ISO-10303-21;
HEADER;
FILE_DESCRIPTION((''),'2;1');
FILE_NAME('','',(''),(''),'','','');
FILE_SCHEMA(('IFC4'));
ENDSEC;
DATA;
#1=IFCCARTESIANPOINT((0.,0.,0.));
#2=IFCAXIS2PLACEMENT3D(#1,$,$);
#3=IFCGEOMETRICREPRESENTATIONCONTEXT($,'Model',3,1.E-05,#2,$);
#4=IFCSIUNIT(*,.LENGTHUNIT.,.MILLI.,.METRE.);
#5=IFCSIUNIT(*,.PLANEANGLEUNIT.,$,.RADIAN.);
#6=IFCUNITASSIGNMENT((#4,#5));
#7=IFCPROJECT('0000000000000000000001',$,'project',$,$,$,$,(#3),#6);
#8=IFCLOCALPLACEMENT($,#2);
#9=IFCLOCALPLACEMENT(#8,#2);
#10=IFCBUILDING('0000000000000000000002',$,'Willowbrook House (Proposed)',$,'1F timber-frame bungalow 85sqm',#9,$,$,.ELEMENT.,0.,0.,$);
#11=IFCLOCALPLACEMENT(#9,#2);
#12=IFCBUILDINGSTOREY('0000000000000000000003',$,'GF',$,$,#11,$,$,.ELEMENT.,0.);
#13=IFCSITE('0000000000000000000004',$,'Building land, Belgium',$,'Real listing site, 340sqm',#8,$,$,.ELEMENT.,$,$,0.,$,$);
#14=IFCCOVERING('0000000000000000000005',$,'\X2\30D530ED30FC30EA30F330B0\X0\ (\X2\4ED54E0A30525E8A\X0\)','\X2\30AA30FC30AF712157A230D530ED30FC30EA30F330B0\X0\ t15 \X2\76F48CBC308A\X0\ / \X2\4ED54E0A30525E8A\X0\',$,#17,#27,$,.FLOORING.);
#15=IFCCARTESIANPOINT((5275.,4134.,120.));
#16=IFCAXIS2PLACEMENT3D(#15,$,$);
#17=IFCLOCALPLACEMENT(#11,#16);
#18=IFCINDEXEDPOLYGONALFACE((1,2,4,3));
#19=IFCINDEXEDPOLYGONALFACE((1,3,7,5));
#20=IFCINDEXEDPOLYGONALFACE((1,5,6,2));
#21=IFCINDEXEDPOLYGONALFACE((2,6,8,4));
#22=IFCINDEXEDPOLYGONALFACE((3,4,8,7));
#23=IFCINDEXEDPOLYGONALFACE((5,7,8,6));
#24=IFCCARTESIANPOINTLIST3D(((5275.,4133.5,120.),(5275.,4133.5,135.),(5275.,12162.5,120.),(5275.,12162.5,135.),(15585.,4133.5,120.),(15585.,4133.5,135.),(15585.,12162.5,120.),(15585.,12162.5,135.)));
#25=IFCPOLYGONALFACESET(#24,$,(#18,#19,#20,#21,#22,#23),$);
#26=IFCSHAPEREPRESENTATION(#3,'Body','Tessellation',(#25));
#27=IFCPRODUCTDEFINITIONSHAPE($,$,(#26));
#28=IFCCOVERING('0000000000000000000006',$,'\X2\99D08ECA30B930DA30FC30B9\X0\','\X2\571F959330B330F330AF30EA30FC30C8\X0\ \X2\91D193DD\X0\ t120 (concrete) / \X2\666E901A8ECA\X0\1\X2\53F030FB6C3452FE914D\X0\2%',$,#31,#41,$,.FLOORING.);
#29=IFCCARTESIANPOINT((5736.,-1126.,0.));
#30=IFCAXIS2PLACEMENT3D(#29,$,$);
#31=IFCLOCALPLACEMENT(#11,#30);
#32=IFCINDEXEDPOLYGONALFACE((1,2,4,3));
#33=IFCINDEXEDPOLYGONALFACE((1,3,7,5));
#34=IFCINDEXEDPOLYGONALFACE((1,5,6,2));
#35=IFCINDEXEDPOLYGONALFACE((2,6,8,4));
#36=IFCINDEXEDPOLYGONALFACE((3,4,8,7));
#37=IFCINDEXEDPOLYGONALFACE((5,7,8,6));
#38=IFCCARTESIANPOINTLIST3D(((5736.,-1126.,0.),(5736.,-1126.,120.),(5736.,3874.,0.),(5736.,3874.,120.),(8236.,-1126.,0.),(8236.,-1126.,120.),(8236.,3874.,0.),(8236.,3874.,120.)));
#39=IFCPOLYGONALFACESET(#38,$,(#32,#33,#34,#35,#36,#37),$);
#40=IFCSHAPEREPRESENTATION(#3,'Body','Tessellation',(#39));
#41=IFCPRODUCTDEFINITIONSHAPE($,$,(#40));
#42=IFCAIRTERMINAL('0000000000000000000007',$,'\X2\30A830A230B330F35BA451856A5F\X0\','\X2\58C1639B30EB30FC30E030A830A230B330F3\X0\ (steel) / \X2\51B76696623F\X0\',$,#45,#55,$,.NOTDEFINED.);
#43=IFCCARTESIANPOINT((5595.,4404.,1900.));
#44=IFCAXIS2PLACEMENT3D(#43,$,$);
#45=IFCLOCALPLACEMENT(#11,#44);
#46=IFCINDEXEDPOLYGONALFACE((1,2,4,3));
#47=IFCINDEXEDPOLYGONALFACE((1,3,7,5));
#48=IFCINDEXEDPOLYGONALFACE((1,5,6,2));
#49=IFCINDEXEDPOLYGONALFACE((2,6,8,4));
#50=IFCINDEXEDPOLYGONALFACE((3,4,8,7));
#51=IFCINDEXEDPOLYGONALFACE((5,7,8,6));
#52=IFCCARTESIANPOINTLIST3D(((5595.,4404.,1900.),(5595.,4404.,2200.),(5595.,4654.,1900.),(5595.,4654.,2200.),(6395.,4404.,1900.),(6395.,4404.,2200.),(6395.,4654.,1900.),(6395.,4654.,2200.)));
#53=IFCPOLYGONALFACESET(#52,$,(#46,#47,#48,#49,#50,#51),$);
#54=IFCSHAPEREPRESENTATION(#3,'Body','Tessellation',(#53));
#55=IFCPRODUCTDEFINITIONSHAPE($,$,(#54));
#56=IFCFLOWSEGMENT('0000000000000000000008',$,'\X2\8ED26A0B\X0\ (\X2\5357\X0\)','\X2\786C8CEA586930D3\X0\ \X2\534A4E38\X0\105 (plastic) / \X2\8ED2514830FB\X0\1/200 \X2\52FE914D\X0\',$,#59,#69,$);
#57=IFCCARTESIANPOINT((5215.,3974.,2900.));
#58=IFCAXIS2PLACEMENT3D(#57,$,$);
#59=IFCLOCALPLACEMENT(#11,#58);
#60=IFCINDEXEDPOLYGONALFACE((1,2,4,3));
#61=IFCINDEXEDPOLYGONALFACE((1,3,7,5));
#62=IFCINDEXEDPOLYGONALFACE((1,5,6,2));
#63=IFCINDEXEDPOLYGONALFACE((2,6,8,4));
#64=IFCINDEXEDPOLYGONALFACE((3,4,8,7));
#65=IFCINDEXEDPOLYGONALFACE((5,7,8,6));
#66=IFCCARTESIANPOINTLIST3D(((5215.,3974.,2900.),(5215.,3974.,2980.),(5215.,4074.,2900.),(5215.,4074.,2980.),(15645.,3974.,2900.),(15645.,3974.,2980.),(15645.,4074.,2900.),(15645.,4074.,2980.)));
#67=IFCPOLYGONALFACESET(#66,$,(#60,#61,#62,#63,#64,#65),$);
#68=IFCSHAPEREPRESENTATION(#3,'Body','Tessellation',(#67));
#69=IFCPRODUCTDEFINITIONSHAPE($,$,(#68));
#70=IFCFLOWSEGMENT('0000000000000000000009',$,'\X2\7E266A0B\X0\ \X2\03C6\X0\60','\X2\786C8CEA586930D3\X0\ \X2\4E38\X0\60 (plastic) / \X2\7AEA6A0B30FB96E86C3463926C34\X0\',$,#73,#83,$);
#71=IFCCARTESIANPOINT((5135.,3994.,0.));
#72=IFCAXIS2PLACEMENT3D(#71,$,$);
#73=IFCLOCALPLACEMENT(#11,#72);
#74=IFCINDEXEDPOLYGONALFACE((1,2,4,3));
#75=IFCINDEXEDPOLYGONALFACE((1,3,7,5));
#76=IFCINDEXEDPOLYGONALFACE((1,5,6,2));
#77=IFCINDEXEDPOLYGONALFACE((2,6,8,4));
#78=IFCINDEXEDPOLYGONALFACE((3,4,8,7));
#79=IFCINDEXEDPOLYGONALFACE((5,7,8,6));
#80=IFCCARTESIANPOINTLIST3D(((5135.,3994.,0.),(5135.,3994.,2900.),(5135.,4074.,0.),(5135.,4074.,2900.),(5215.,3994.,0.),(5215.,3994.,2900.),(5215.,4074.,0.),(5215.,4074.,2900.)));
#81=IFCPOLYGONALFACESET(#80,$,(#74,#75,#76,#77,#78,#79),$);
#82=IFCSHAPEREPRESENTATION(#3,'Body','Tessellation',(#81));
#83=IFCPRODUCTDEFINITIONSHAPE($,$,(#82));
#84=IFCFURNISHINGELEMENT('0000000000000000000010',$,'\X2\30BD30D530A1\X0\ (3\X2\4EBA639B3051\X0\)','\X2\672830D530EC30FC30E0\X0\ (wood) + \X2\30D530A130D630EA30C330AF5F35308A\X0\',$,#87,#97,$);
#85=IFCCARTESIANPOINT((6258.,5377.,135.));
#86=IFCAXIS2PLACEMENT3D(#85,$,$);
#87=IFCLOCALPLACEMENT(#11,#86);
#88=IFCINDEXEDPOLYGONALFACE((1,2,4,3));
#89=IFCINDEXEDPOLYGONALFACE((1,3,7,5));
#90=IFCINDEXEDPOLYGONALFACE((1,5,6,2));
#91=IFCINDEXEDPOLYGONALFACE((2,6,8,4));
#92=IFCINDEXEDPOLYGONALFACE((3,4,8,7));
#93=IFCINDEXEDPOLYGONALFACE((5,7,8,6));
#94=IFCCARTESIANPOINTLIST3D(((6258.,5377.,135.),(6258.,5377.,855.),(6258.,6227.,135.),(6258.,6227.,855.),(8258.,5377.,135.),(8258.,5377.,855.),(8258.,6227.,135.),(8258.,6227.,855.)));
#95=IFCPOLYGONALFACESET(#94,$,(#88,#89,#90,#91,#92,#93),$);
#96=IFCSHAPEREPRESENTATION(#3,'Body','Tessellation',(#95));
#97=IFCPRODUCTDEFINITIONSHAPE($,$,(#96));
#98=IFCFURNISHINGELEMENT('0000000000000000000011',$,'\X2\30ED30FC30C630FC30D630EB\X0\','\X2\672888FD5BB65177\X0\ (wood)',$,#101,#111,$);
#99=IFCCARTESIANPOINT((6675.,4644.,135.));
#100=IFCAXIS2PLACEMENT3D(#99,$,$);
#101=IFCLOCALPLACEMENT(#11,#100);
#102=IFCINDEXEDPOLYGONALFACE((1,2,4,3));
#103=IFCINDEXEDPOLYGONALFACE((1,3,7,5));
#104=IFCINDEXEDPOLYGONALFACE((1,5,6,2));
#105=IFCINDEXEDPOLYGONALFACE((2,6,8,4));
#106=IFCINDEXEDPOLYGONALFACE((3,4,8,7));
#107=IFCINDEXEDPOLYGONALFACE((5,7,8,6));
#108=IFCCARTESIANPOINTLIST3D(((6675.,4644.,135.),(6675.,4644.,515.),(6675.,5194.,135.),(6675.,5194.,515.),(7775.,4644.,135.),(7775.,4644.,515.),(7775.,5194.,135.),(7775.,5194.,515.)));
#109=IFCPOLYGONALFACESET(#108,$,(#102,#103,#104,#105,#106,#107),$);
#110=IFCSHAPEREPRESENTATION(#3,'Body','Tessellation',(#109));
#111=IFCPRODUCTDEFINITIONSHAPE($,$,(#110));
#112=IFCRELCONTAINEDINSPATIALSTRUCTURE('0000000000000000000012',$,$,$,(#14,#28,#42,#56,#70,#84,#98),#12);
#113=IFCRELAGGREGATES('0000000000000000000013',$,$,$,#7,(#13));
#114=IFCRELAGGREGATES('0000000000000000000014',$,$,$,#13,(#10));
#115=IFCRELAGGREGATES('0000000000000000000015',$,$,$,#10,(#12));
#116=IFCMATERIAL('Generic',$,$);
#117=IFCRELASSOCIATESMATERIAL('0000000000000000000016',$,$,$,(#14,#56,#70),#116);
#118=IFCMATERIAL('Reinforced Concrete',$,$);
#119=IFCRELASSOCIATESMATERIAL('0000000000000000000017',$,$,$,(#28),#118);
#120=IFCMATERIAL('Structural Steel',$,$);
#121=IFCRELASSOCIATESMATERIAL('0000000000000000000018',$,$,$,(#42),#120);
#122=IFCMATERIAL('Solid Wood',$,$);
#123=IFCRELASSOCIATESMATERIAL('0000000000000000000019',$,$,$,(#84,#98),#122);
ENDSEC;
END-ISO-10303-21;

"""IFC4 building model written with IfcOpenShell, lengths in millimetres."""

from ifc_helpers import new_model, si_unit, frame, frame_2d, origin, place, context, project, spatial, rectangle, extrude, material, element, save


model = new_model("IFC4")

# Units and contexts
model_context = context("Model", 3, precision=1e-05, world=origin())
ifc_project = project(units=[si_unit("LENGTHUNIT", "METRE", prefix="MILLI"), si_unit("PLANEANGLEUNIT", "RADIAN")], contexts=[model_context])

# Site, building, storey
site_placement = place(None, origin())
site = spatial("IfcSite", under=ifc_project, at=site_placement, Name="Building land, Belgium", ObjectType="Real listing site, 340sqm", CompositionType="ELEMENT", RefElevation=0.0)
building_placement = place(site_placement, origin())
building = spatial("IfcBuilding", under=site, at=building_placement, Name="Willowbrook House (Proposed)", ObjectType="1F timber-frame bungalow 85sqm", CompositionType="ELEMENT", ElevationOfRefHeight=0.0, ElevationOfTerrain=0.0)
storey_placement = place(building_placement, origin())
storey = spatial("IfcBuildingStorey", under=building, at=storey_placement, Name="GF", CompositionType="ELEMENT", Elevation=0.0)

# Shared definitions
ifc_material_1 = material(Name="Solid Wood")

# Shared definitions
ifc_material_2 = material(Name="Reinforced Concrete")

# Shared definitions
ifc_material_3 = material(Name="Structural Steel")

# Coverings
ifc_material_4 = material(Name="Generic")
covering_1_placement = place(storey_placement, frame((5275.0, 4134.0, 120.0)))
element("IfcCovering", 1, at=covering_1_placement, inside=storey, material=ifc_material_4, Name="フローリング (仕上げ床)", Description="オーク無垢フローリング t15 直貼り / 仕上げ床", PredefinedType="FLOORING", context=model_context, shape_type="SweptSolid", body=[
    extrude(rectangle(XDim=10310.0, YDim=8029.0, at=frame_2d((5155.0, 4014.0))), frame((5275.0, 4134.0, 120.0)), (0.0, 0.0, 1.0), 15.0),
])
covering_2_placement = place(storey_placement, frame((5736.0, -1126.0, 0.0)))
element("IfcCovering", 2, at=covering_2_placement, inside=storey, material=ifc_material_2, Name="駐車スペース", Description="土間コンクリート 金鏝 t120 (concrete) / 普通車1台・水勾配2%", PredefinedType="FLOORING", context=model_context, shape_type="SweptSolid", body=[
    extrude(rectangle(XDim=2500.0, YDim=5000.0, at=frame_2d((1250.0, 2500.0))), frame((5736.0, -1126.0, 0.0)), (0.0, 0.0, 1.0), 120.0),
])

# Air terminal
air_terminal_placement = place(storey_placement, frame((5595.0, 4404.0, 1900.0)))
element("IfcAirTerminal", 3, at=air_terminal_placement, inside=storey, material=ifc_material_3, Name="エアコン室内機", Description="壁掛ルームエアコン (steel) / 冷暖房", PredefinedType="NOTDEFINED", context=model_context, shape_type="SweptSolid", body=[
    extrude(rectangle(XDim=800.0, YDim=250.0, at=frame_2d((400.0, 125.0))), frame((5595.0, 4404.0, 1900.0)), (0.0, 0.0, 1.0), 300.0),
])

# Flow segments
flow_segment_1_placement = place(storey_placement, frame((5215.0, 3974.0, 2900.0)))
element("IfcFlowSegment", 4, at=flow_segment_1_placement, inside=storey, material=ifc_material_4, Name="軒樋 (南)", Description="硬質塩ビ 半丸105 (plastic) / 軒先・1/200 勾配", context=model_context, shape_type="SweptSolid", body=[
    extrude(rectangle(XDim=10430.0, YDim=100.0, at=frame_2d((5215.0, 50.0))), frame((5215.0, 3974.0, 2900.0)), (0.0, 0.0, 1.0), 80.0),
])
flow_segment_2_placement = place(storey_placement, frame((5135.0, 3994.0, 0.0)))
element("IfcFlowSegment", 5, at=flow_segment_2_placement, inside=storey, material=ifc_material_4, Name="縦樋 φ60", Description="硬質塩ビ 丸60 (plastic) / 竪樋・雨水排水", context=model_context, shape_type="SweptSolid", body=[
    extrude(rectangle(XDim=80.0, YDim=80.0, at=frame_2d((40.0, 40.0))), frame((5135.0, 3994.0, 0.0)), (0.0, 0.0, 1.0), 2900.0),
])

# Furnishing elements
furnishing_1_placement = place(storey_placement, frame((6258.0, 5377.0, 135.0)))
element("IfcFurnishingElement", 6, at=furnishing_1_placement, inside=storey, material=ifc_material_1, Name="ソファ (3人掛け)", Description="木フレーム (wood) + ファブリック張り", context=model_context, shape_type="SweptSolid", body=[
    extrude(rectangle(XDim=2000.0, YDim=850.0, at=frame_2d((1000.0, 425.0))), frame((6258.0, 5377.0, 135.0)), (0.0, 0.0, 1.0), 720.0),
])
furnishing_2_placement = place(storey_placement, frame((6675.0, 4644.0, 135.0)))
element("IfcFurnishingElement", 7, at=furnishing_2_placement, inside=storey, material=ifc_material_1, Name="ローテーブル", Description="木製家具 (wood)", context=model_context, shape_type="SweptSolid", body=[
    extrude(rectangle(XDim=1100.0, YDim=550.0, at=frame_2d((550.0, 275.0))), frame((6675.0, 4644.0, 135.0)), (0.0, 0.0, 1.0), 380.0),
])

save(model, "model.ifc")
